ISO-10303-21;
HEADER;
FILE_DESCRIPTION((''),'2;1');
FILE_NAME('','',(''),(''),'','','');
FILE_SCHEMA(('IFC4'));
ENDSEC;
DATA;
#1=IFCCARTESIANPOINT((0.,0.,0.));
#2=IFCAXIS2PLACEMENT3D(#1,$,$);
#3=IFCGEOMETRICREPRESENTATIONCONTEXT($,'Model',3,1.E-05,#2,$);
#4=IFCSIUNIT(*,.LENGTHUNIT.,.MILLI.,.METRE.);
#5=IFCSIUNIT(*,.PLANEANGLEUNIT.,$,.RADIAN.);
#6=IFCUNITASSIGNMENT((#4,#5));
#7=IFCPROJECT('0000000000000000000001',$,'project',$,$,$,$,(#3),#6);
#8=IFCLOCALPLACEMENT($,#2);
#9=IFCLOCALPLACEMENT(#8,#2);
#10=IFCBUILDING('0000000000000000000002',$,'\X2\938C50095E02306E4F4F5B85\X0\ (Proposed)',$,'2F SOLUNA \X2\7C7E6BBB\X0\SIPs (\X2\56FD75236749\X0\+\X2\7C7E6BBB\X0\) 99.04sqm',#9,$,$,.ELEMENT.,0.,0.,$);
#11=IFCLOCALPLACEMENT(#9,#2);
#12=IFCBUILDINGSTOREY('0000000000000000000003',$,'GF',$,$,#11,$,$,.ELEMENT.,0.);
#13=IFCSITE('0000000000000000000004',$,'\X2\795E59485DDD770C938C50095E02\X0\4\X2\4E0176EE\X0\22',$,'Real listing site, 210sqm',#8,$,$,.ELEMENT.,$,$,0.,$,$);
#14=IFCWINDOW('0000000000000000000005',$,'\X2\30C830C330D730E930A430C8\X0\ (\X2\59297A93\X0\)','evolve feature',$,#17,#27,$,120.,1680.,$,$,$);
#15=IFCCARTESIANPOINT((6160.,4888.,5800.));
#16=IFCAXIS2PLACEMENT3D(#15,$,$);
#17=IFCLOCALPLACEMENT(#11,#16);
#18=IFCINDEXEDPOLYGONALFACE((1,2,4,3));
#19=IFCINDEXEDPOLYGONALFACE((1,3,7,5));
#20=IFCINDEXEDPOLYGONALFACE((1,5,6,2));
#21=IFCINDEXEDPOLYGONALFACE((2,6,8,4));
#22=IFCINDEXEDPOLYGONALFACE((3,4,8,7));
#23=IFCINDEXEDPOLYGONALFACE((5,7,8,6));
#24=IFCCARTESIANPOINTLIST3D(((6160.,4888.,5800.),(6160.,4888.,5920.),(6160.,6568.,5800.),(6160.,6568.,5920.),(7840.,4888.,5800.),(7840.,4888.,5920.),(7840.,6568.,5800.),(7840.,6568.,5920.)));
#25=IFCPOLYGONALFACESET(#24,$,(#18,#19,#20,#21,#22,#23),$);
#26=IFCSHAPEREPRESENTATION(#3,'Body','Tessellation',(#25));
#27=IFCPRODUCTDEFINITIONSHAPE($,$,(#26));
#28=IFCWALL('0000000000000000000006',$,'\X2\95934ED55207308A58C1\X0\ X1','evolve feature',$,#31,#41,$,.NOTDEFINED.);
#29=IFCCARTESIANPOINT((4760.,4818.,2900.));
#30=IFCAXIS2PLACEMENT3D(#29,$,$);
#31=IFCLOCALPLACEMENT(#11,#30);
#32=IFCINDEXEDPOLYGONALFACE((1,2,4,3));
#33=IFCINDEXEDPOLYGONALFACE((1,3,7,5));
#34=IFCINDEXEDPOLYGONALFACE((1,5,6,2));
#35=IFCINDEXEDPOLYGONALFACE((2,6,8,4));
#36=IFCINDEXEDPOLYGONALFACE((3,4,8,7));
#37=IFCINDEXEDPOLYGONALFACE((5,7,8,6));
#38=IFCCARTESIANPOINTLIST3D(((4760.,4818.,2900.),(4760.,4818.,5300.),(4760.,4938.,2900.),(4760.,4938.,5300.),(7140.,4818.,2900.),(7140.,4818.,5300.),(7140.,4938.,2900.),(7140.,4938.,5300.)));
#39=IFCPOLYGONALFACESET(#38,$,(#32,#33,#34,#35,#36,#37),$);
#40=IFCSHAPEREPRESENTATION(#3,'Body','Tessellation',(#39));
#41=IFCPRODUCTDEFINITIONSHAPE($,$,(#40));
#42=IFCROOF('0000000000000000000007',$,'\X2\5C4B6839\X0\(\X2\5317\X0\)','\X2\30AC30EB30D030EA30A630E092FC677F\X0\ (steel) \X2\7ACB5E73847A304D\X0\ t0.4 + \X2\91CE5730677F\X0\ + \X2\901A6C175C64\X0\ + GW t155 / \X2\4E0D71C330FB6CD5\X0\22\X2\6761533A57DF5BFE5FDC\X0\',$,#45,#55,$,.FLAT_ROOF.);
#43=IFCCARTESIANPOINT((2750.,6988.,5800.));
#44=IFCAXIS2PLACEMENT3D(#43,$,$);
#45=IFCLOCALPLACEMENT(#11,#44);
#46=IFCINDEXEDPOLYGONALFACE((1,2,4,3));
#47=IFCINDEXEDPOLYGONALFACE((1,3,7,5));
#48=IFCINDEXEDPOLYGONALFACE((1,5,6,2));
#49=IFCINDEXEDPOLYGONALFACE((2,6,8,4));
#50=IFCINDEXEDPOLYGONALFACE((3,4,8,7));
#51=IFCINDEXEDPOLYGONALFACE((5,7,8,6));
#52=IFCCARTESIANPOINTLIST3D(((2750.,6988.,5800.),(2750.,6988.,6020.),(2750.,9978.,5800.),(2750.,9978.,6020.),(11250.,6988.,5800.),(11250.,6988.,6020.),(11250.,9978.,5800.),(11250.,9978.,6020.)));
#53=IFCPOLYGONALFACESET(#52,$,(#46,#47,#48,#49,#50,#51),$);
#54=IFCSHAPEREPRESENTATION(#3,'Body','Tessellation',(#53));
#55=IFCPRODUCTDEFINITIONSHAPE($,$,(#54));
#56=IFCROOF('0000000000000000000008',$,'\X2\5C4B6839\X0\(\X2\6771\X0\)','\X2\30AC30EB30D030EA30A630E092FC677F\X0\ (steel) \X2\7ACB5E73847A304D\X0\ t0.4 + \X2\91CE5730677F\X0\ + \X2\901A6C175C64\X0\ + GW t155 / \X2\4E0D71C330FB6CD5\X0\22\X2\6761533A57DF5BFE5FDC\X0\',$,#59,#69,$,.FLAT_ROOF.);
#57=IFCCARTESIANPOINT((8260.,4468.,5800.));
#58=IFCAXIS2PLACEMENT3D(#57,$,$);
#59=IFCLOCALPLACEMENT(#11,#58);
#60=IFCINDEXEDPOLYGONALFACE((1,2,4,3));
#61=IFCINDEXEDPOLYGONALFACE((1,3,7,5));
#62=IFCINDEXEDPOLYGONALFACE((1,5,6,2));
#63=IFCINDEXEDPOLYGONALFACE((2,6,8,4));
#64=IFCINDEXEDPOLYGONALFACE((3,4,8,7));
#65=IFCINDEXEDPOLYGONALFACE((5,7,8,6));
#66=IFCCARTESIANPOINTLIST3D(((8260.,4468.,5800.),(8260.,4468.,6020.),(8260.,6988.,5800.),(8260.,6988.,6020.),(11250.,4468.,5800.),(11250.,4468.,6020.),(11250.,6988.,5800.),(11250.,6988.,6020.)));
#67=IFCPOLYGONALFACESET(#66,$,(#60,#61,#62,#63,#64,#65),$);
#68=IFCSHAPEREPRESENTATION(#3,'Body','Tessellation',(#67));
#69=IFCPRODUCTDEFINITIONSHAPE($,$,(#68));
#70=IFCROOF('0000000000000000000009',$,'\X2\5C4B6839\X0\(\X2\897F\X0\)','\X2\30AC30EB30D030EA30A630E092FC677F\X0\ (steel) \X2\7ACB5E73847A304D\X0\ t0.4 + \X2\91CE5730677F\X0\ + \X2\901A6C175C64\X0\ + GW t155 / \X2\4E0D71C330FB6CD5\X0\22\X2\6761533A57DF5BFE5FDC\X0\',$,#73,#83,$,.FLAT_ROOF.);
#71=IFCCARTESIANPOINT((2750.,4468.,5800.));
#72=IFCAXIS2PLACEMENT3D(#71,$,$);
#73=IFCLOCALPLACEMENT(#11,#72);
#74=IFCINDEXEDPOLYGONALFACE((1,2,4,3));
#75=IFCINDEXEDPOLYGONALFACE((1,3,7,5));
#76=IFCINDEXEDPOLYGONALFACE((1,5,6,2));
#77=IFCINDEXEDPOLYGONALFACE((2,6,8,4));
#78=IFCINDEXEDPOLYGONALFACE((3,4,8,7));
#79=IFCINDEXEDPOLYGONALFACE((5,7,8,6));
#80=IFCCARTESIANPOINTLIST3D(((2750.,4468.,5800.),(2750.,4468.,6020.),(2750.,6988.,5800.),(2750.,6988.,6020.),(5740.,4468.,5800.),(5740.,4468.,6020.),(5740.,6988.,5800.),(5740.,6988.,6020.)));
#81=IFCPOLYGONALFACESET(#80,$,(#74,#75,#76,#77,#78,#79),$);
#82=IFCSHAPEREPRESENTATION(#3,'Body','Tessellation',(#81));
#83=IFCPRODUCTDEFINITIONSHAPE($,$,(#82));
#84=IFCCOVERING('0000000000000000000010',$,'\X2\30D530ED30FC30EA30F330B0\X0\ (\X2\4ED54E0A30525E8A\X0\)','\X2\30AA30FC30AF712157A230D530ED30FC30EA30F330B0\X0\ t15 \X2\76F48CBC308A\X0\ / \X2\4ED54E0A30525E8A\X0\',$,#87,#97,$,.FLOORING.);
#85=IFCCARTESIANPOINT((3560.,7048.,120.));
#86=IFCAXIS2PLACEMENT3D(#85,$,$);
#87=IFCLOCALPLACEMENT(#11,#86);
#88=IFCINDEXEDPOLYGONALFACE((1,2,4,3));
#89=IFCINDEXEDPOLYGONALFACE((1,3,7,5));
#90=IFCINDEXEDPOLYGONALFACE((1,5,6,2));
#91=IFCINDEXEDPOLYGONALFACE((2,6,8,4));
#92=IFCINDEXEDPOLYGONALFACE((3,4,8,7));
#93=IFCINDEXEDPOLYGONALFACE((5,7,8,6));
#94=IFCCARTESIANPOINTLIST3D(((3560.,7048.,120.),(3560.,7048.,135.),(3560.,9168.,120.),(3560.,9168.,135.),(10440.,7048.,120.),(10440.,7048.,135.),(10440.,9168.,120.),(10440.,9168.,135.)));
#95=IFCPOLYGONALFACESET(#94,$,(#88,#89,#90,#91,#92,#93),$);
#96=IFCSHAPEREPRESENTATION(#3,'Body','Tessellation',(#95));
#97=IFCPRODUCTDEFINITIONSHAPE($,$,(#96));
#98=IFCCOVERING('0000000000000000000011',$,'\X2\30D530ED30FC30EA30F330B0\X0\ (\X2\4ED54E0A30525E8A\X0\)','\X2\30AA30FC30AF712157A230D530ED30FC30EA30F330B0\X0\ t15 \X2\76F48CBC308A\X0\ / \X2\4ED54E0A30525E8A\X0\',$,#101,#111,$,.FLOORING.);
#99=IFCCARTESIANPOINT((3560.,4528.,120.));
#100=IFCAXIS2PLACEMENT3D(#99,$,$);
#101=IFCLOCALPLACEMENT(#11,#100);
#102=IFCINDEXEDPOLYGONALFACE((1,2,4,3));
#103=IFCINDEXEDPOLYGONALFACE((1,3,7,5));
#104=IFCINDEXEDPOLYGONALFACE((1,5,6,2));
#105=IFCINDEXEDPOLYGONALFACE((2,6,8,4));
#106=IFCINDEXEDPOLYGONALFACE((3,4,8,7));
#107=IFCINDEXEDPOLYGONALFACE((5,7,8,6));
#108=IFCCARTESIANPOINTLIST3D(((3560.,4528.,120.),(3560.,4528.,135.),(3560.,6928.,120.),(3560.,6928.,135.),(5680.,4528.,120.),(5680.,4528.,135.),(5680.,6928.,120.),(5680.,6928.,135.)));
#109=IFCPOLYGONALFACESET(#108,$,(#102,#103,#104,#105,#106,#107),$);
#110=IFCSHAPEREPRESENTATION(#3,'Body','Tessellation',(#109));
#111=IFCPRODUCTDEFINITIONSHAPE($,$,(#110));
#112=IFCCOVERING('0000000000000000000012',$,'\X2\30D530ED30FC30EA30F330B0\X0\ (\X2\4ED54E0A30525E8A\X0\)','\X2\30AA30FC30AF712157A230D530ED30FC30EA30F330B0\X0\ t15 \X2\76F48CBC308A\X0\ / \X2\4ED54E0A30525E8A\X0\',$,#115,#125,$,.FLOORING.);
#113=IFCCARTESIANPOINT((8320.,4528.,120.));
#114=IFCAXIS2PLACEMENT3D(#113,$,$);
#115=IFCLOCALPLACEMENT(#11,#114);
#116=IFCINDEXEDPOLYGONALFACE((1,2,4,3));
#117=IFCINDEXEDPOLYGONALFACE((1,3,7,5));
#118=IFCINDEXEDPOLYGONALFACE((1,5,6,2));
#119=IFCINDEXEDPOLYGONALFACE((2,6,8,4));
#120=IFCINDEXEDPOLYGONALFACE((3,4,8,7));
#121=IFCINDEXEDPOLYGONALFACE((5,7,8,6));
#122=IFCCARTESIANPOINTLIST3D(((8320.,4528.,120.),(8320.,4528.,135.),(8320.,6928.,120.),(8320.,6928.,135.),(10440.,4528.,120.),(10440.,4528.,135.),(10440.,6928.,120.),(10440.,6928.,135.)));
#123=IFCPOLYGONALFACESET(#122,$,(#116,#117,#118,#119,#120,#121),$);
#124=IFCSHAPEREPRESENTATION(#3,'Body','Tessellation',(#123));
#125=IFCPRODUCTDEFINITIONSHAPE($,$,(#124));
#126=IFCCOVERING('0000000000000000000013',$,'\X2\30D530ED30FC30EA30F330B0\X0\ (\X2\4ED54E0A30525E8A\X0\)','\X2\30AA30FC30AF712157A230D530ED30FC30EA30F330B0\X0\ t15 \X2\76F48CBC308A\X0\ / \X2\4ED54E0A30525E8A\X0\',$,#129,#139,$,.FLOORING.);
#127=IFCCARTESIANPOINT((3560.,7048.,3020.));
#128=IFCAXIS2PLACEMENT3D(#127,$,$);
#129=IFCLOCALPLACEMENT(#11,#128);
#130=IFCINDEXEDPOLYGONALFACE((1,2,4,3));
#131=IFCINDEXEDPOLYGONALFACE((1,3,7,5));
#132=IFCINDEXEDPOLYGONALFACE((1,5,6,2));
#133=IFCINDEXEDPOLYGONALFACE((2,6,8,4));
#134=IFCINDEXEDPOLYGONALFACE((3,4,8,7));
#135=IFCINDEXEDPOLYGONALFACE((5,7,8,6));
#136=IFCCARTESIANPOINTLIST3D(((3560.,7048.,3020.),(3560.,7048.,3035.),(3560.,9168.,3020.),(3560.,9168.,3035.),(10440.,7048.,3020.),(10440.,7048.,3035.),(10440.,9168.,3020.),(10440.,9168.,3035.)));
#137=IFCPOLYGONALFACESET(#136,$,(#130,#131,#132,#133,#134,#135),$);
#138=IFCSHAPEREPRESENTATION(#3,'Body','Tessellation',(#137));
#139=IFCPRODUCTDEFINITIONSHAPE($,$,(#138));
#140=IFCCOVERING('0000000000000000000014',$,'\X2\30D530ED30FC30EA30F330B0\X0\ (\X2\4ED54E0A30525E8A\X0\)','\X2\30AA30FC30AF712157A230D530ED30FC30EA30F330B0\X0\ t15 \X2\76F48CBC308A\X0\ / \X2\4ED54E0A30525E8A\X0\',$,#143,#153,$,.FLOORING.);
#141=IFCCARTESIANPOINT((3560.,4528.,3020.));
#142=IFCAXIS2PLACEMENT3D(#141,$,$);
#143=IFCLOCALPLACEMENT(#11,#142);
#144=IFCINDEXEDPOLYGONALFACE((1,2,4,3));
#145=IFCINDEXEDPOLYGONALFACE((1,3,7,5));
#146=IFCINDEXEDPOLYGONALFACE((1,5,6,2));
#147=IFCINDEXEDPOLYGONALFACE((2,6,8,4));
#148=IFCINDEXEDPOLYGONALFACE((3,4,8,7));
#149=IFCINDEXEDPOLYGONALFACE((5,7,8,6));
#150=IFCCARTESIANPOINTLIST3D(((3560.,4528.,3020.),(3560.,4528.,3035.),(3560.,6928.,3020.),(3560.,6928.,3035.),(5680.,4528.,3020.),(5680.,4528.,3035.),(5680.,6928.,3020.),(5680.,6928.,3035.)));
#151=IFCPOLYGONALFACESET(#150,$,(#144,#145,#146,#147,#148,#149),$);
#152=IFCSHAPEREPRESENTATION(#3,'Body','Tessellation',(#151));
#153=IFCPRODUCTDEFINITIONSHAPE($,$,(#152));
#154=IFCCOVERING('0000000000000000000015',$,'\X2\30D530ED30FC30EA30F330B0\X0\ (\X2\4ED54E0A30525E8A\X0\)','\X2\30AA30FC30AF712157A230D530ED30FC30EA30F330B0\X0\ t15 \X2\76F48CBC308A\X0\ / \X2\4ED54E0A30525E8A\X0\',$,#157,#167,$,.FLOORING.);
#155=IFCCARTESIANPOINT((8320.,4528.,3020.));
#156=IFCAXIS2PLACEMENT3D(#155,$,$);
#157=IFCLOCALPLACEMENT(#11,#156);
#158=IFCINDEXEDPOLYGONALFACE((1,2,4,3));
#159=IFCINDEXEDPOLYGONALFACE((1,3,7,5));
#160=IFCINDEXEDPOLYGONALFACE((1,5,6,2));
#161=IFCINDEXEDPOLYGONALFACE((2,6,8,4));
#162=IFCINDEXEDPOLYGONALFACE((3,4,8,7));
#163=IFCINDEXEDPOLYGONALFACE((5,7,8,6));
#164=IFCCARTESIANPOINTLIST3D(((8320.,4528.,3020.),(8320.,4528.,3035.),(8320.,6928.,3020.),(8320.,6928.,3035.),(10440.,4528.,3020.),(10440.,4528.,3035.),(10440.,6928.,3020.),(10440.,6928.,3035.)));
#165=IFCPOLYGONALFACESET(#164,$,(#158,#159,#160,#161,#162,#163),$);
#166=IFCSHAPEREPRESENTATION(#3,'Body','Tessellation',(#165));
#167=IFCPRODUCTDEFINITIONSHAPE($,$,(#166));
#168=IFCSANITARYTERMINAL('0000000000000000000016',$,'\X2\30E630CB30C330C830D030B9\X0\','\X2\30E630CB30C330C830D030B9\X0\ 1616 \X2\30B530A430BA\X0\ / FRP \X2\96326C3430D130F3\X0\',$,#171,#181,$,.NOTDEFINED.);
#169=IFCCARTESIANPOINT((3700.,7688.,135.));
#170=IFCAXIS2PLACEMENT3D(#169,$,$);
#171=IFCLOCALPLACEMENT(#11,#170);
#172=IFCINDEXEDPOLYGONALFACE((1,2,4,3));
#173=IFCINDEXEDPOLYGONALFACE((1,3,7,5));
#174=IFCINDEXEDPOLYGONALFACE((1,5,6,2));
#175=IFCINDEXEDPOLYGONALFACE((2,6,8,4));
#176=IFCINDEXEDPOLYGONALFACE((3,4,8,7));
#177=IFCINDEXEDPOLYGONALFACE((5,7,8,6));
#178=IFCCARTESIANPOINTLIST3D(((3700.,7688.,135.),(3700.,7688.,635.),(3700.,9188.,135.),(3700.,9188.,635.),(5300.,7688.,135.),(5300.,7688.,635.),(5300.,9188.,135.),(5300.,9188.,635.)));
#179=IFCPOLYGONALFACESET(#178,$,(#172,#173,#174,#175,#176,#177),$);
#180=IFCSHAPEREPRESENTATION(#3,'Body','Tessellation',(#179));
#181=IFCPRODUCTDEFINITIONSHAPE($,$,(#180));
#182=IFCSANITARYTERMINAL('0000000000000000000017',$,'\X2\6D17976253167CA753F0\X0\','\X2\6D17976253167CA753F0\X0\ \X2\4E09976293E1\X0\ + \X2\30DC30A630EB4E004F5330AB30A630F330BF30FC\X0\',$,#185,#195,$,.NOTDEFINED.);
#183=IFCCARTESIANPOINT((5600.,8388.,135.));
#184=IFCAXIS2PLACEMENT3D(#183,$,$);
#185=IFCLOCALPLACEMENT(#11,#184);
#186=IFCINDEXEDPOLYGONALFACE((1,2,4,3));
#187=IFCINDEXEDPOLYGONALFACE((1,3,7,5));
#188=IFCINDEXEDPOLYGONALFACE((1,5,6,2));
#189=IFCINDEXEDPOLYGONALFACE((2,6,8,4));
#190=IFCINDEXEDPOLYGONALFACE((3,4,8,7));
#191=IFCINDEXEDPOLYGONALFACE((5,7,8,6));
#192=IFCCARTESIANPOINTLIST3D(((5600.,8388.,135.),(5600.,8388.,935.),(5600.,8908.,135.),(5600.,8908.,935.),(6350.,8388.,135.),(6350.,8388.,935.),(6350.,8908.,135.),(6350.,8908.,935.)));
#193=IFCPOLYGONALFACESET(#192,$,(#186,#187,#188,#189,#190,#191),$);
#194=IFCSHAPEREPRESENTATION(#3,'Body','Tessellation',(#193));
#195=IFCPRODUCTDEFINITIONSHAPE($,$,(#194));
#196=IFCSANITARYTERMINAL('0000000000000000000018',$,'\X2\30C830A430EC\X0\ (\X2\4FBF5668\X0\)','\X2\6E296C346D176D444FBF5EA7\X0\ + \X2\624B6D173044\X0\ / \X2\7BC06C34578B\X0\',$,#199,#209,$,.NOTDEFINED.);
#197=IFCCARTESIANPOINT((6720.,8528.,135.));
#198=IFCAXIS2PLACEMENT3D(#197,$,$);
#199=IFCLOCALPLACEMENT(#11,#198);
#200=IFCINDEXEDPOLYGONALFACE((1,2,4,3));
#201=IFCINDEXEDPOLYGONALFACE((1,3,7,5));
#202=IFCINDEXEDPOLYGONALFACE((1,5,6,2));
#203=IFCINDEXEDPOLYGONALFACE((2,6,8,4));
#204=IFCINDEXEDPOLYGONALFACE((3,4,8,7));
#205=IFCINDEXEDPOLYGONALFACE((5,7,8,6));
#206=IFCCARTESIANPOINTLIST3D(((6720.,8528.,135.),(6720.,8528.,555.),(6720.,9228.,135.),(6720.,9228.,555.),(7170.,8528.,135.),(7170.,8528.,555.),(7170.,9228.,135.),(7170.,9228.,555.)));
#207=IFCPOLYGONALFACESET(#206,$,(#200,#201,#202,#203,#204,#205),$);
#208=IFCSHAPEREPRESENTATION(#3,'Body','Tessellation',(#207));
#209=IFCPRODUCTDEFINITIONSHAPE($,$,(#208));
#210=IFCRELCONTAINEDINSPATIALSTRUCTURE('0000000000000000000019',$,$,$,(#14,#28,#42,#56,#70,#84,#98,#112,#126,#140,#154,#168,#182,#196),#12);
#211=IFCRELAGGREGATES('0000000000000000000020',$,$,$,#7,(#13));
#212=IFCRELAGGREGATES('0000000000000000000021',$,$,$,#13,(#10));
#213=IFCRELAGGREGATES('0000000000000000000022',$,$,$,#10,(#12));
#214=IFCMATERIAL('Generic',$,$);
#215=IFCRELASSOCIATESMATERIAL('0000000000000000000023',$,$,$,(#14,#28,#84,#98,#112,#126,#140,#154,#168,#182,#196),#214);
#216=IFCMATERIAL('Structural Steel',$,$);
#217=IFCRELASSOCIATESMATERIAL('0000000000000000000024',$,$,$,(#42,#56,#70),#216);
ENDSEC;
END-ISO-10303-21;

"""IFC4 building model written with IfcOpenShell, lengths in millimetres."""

from ifc_helpers import new_model, si_unit, frame, frame_2d, origin, place, context, project, spatial, rectangle, extrude, material, element, save


model = new_model("IFC4")

# Units and contexts
model_context = context("Model", 3, precision=1e-05, world=origin())
ifc_project = project(units=[si_unit("LENGTHUNIT", "METRE", prefix="MILLI"), si_unit("PLANEANGLEUNIT", "RADIAN")], contexts=[model_context])

# Site, building, storey
site_placement = place(None, origin())
site = spatial("IfcSite", under=ifc_project, at=site_placement, Name="神奈川県鎌倉市4丁目22", ObjectType="Real listing site, 210sqm", CompositionType="ELEMENT", RefElevation=0.0)
building_placement = place(site_placement, origin())
building = spatial("IfcBuilding", under=site, at=building_placement, Name="鎌倉市の住宅 (Proposed)", ObjectType="2F SOLUNA 籾殻SIPs (国産杉+籾殻) 99.04sqm", CompositionType="ELEMENT", ElevationOfRefHeight=0.0, ElevationOfTerrain=0.0)
storey_placement = place(building_placement, origin())
storey = spatial("IfcBuildingStorey", under=building, at=storey_placement, Name="GF", CompositionType="ELEMENT", Elevation=0.0)

# Window
ifc_material_1 = material(Name="Generic")
window_1_placement = place(storey_placement, frame((6160.0, 4888.0, 5800.0)))
element("IfcWindow", 1, at=window_1_placement, inside=storey, material=ifc_material_1, Name="トップライト (天窓)", Description="evolve feature", OverallHeight=120.0, OverallWidth=1680.0, context=model_context, shape_type="SweptSolid", body=[
    extrude(rectangle(XDim=1680.0, YDim=1680.0, at=frame_2d((840.0, 840.0))), frame((6160.0, 4888.0, 5800.0)), (0.0, 0.0, 1.0), 120.0),
])

# Wall
wall_1_placement = place(storey_placement, frame((4760.0, 4818.0, 2900.0)))
element("IfcWall", 2, at=wall_1_placement, inside=storey, material=ifc_material_1, Name="間仕切り壁 X1", Description="evolve feature", PredefinedType="NOTDEFINED", context=model_context, shape_type="SweptSolid", body=[
    extrude(rectangle(XDim=2380.0, YDim=120.0, at=frame_2d((1190.0, 60.0))), frame((4760.0, 4818.0, 2900.0)), (0.0, 0.0, 1.0), 2400.0),
])

# Roofs
ifc_material_2 = material(Name="Structural Steel")
roof_1_placement = place(storey_placement, frame((2750.0, 6988.0, 5800.0)))
element("IfcRoof", 3, at=roof_1_placement, inside=storey, material=ifc_material_2, Name="屋根(北)", Description="ガルバリウム鋼板 (steel) 立平葺き t0.4 + 野地板 + 通気層 + GW t155 / 不燃・法22条区域対応", PredefinedType="FLAT_ROOF", context=model_context, shape_type="SweptSolid", body=[
    extrude(rectangle(XDim=8500.0, YDim=2990.0, at=frame_2d((4250.0, 1495.0))), frame((2750.0, 6988.0, 5800.0)), (0.0, 0.0, 1.0), 220.0),
])
roof_2_placement = place(storey_placement, frame((8260.0, 4468.0, 5800.0)))
element("IfcRoof", 4, at=roof_2_placement, inside=storey, material=ifc_material_2, Name="屋根(東)", Description="ガルバリウム鋼板 (steel) 立平葺き t0.4 + 野地板 + 通気層 + GW t155 / 不燃・法22条区域対応", PredefinedType="FLAT_ROOF", context=model_context, shape_type="SweptSolid", body=[
    extrude(rectangle(XDim=2990.0, YDim=2520.0, at=frame_2d((1495.0, 1260.0))), frame((8260.0, 4468.0, 5800.0)), (0.0, 0.0, 1.0), 220.0),
])
roof_3_placement = place(storey_placement, frame((2750.0, 4468.0, 5800.0)))
element("IfcRoof", 5, at=roof_3_placement, inside=storey, material=ifc_material_2, Name="屋根(西)", Description="ガルバリウム鋼板 (steel) 立平葺き t0.4 + 野地板 + 通気層 + GW t155 / 不燃・法22条区域対応", PredefinedType="FLAT_ROOF", context=model_context, shape_type="SweptSolid", body=[
    extrude(rectangle(XDim=2990.0, YDim=2520.0, at=frame_2d((1495.0, 1260.0))), frame((2750.0, 4468.0, 5800.0)), (0.0, 0.0, 1.0), 220.0),
])

# Coverings
covering_1_placement = place(storey_placement, frame((3560.0, 7048.0, 120.0)))
element("IfcCovering", 6, at=covering_1_placement, inside=storey, material=ifc_material_1, Name="フローリング (仕上げ床)", Description="オーク無垢フローリング t15 直貼り / 仕上げ床", PredefinedType="FLOORING", context=model_context, shape_type="SweptSolid", body=[
    extrude(rectangle(XDim=6880.0, YDim=2120.0, at=frame_2d((3440.0, 1060.0))), frame((3560.0, 7048.0, 120.0)), (0.0, 0.0, 1.0), 15.0),
])
covering_2_placement = place(storey_placement, frame((3560.0, 4528.0, 120.0)))
element("IfcCovering", 7, at=covering_2_placement, inside=storey, material=ifc_material_1, Name="フローリング (仕上げ床)", Description="オーク無垢フローリング t15 直貼り / 仕上げ床", PredefinedType="FLOORING", context=model_context, shape_type="SweptSolid", body=[
    extrude(rectangle(XDim=2120.0, YDim=2400.0, at=frame_2d((1060.0, 1200.0))), frame((3560.0, 4528.0, 120.0)), (0.0, 0.0, 1.0), 15.0),
])
covering_3_placement = place(storey_placement, frame((8320.0, 4528.0, 120.0)))
element("IfcCovering", 8, at=covering_3_placement, inside=storey, material=ifc_material_1, Name="フローリング (仕上げ床)", Description="オーク無垢フローリング t15 直貼り / 仕上げ床", PredefinedType="FLOORING", context=model_context, shape_type="SweptSolid", body=[
    extrude(rectangle(XDim=2120.0, YDim=2400.0, at=frame_2d((1060.0, 1200.0))), frame((8320.0, 4528.0, 120.0)), (0.0, 0.0, 1.0), 15.0),
])
covering_4_placement = place(storey_placement, frame((3560.0, 7048.0, 3020.0)))
element("IfcCovering", 9, at=covering_4_placement, inside=storey, material=ifc_material_1, Name="フローリング (仕上げ床)", Description="オーク無垢フローリング t15 直貼り / 仕上げ床", PredefinedType="FLOORING", context=model_context, shape_type="SweptSolid", body=[
    extrude(rectangle(XDim=6880.0, YDim=2120.0, at=frame_2d((3440.0, 1060.0))), frame((3560.0, 7048.0, 3020.0)), (0.0, 0.0, 1.0), 15.0),
])
covering_5_placement = place(storey_placement, frame((3560.0, 4528.0, 3020.0)))
element("IfcCovering", 10, at=covering_5_placement, inside=storey, material=ifc_material_1, Name="フローリング (仕上げ床)", Description="オーク無垢フローリング t15 直貼り / 仕上げ床", PredefinedType="FLOORING", context=model_context, shape_type="SweptSolid", body=[
    extrude(rectangle(XDim=2120.0, YDim=2400.0, at=frame_2d((1060.0, 1200.0))), frame((3560.0, 4528.0, 3020.0)), (0.0, 0.0, 1.0), 15.0),
])
covering_6_placement = place(storey_placement, frame((8320.0, 4528.0, 3020.0)))
element("IfcCovering", 11, at=covering_6_placement, inside=storey, material=ifc_material_1, Name="フローリング (仕上げ床)", Description="オーク無垢フローリング t15 直貼り / 仕上げ床", PredefinedType="FLOORING", context=model_context, shape_type="SweptSolid", body=[
    extrude(rectangle(XDim=2120.0, YDim=2400.0, at=frame_2d((1060.0, 1200.0))), frame((8320.0, 4528.0, 3020.0)), (0.0, 0.0, 1.0), 15.0),
])

# Sanitary terminals
sanitary_terminal_1_placement = place(storey_placement, frame((3700.0, 7688.0, 135.0)))
element("IfcSanitaryTerminal", 12, at=sanitary_terminal_1_placement, inside=storey, material=ifc_material_1, Name="ユニットバス", Description="ユニットバス 1616 サイズ / FRP 防水パン", PredefinedType="NOTDEFINED", context=model_context, shape_type="SweptSolid", body=[
    extrude(rectangle(XDim=1600.0, YDim=1500.0, at=frame_2d((800.0, 750.0))), frame((3700.0, 7688.0, 135.0)), (0.0, 0.0, 1.0), 500.0),
])
sanitary_terminal_2_placement = place(storey_placement, frame((5600.0, 8388.0, 135.0)))
element("IfcSanitaryTerminal", 13, at=sanitary_terminal_2_placement, inside=storey, material=ifc_material_1, Name="洗面化粧台", Description="洗面化粧台 三面鏡 + ボウル一体カウンター", PredefinedType="NOTDEFINED", context=model_context, shape_type="SweptSolid", body=[
    extrude(rectangle(XDim=750.0, YDim=520.0, at=frame_2d((375.0, 260.0))), frame((5600.0, 8388.0, 135.0)), (0.0, 0.0, 1.0), 800.0),
])
sanitary_terminal_3_placement = place(storey_placement, frame((6720.0, 8528.0, 135.0)))
element("IfcSanitaryTerminal", 14, at=sanitary_terminal_3_placement, inside=storey, material=ifc_material_1, Name="トイレ (便器)", Description="温水洗浄便座 + 手洗い / 節水型", PredefinedType="NOTDEFINED", context=model_context, shape_type="SweptSolid", body=[
    extrude(rectangle(XDim=450.0, YDim=700.0, at=frame_2d((225.0, 350.0))), frame((6720.0, 8528.0, 135.0)), (0.0, 0.0, 1.0), 420.0),
])

save(model, "model.ifc")
